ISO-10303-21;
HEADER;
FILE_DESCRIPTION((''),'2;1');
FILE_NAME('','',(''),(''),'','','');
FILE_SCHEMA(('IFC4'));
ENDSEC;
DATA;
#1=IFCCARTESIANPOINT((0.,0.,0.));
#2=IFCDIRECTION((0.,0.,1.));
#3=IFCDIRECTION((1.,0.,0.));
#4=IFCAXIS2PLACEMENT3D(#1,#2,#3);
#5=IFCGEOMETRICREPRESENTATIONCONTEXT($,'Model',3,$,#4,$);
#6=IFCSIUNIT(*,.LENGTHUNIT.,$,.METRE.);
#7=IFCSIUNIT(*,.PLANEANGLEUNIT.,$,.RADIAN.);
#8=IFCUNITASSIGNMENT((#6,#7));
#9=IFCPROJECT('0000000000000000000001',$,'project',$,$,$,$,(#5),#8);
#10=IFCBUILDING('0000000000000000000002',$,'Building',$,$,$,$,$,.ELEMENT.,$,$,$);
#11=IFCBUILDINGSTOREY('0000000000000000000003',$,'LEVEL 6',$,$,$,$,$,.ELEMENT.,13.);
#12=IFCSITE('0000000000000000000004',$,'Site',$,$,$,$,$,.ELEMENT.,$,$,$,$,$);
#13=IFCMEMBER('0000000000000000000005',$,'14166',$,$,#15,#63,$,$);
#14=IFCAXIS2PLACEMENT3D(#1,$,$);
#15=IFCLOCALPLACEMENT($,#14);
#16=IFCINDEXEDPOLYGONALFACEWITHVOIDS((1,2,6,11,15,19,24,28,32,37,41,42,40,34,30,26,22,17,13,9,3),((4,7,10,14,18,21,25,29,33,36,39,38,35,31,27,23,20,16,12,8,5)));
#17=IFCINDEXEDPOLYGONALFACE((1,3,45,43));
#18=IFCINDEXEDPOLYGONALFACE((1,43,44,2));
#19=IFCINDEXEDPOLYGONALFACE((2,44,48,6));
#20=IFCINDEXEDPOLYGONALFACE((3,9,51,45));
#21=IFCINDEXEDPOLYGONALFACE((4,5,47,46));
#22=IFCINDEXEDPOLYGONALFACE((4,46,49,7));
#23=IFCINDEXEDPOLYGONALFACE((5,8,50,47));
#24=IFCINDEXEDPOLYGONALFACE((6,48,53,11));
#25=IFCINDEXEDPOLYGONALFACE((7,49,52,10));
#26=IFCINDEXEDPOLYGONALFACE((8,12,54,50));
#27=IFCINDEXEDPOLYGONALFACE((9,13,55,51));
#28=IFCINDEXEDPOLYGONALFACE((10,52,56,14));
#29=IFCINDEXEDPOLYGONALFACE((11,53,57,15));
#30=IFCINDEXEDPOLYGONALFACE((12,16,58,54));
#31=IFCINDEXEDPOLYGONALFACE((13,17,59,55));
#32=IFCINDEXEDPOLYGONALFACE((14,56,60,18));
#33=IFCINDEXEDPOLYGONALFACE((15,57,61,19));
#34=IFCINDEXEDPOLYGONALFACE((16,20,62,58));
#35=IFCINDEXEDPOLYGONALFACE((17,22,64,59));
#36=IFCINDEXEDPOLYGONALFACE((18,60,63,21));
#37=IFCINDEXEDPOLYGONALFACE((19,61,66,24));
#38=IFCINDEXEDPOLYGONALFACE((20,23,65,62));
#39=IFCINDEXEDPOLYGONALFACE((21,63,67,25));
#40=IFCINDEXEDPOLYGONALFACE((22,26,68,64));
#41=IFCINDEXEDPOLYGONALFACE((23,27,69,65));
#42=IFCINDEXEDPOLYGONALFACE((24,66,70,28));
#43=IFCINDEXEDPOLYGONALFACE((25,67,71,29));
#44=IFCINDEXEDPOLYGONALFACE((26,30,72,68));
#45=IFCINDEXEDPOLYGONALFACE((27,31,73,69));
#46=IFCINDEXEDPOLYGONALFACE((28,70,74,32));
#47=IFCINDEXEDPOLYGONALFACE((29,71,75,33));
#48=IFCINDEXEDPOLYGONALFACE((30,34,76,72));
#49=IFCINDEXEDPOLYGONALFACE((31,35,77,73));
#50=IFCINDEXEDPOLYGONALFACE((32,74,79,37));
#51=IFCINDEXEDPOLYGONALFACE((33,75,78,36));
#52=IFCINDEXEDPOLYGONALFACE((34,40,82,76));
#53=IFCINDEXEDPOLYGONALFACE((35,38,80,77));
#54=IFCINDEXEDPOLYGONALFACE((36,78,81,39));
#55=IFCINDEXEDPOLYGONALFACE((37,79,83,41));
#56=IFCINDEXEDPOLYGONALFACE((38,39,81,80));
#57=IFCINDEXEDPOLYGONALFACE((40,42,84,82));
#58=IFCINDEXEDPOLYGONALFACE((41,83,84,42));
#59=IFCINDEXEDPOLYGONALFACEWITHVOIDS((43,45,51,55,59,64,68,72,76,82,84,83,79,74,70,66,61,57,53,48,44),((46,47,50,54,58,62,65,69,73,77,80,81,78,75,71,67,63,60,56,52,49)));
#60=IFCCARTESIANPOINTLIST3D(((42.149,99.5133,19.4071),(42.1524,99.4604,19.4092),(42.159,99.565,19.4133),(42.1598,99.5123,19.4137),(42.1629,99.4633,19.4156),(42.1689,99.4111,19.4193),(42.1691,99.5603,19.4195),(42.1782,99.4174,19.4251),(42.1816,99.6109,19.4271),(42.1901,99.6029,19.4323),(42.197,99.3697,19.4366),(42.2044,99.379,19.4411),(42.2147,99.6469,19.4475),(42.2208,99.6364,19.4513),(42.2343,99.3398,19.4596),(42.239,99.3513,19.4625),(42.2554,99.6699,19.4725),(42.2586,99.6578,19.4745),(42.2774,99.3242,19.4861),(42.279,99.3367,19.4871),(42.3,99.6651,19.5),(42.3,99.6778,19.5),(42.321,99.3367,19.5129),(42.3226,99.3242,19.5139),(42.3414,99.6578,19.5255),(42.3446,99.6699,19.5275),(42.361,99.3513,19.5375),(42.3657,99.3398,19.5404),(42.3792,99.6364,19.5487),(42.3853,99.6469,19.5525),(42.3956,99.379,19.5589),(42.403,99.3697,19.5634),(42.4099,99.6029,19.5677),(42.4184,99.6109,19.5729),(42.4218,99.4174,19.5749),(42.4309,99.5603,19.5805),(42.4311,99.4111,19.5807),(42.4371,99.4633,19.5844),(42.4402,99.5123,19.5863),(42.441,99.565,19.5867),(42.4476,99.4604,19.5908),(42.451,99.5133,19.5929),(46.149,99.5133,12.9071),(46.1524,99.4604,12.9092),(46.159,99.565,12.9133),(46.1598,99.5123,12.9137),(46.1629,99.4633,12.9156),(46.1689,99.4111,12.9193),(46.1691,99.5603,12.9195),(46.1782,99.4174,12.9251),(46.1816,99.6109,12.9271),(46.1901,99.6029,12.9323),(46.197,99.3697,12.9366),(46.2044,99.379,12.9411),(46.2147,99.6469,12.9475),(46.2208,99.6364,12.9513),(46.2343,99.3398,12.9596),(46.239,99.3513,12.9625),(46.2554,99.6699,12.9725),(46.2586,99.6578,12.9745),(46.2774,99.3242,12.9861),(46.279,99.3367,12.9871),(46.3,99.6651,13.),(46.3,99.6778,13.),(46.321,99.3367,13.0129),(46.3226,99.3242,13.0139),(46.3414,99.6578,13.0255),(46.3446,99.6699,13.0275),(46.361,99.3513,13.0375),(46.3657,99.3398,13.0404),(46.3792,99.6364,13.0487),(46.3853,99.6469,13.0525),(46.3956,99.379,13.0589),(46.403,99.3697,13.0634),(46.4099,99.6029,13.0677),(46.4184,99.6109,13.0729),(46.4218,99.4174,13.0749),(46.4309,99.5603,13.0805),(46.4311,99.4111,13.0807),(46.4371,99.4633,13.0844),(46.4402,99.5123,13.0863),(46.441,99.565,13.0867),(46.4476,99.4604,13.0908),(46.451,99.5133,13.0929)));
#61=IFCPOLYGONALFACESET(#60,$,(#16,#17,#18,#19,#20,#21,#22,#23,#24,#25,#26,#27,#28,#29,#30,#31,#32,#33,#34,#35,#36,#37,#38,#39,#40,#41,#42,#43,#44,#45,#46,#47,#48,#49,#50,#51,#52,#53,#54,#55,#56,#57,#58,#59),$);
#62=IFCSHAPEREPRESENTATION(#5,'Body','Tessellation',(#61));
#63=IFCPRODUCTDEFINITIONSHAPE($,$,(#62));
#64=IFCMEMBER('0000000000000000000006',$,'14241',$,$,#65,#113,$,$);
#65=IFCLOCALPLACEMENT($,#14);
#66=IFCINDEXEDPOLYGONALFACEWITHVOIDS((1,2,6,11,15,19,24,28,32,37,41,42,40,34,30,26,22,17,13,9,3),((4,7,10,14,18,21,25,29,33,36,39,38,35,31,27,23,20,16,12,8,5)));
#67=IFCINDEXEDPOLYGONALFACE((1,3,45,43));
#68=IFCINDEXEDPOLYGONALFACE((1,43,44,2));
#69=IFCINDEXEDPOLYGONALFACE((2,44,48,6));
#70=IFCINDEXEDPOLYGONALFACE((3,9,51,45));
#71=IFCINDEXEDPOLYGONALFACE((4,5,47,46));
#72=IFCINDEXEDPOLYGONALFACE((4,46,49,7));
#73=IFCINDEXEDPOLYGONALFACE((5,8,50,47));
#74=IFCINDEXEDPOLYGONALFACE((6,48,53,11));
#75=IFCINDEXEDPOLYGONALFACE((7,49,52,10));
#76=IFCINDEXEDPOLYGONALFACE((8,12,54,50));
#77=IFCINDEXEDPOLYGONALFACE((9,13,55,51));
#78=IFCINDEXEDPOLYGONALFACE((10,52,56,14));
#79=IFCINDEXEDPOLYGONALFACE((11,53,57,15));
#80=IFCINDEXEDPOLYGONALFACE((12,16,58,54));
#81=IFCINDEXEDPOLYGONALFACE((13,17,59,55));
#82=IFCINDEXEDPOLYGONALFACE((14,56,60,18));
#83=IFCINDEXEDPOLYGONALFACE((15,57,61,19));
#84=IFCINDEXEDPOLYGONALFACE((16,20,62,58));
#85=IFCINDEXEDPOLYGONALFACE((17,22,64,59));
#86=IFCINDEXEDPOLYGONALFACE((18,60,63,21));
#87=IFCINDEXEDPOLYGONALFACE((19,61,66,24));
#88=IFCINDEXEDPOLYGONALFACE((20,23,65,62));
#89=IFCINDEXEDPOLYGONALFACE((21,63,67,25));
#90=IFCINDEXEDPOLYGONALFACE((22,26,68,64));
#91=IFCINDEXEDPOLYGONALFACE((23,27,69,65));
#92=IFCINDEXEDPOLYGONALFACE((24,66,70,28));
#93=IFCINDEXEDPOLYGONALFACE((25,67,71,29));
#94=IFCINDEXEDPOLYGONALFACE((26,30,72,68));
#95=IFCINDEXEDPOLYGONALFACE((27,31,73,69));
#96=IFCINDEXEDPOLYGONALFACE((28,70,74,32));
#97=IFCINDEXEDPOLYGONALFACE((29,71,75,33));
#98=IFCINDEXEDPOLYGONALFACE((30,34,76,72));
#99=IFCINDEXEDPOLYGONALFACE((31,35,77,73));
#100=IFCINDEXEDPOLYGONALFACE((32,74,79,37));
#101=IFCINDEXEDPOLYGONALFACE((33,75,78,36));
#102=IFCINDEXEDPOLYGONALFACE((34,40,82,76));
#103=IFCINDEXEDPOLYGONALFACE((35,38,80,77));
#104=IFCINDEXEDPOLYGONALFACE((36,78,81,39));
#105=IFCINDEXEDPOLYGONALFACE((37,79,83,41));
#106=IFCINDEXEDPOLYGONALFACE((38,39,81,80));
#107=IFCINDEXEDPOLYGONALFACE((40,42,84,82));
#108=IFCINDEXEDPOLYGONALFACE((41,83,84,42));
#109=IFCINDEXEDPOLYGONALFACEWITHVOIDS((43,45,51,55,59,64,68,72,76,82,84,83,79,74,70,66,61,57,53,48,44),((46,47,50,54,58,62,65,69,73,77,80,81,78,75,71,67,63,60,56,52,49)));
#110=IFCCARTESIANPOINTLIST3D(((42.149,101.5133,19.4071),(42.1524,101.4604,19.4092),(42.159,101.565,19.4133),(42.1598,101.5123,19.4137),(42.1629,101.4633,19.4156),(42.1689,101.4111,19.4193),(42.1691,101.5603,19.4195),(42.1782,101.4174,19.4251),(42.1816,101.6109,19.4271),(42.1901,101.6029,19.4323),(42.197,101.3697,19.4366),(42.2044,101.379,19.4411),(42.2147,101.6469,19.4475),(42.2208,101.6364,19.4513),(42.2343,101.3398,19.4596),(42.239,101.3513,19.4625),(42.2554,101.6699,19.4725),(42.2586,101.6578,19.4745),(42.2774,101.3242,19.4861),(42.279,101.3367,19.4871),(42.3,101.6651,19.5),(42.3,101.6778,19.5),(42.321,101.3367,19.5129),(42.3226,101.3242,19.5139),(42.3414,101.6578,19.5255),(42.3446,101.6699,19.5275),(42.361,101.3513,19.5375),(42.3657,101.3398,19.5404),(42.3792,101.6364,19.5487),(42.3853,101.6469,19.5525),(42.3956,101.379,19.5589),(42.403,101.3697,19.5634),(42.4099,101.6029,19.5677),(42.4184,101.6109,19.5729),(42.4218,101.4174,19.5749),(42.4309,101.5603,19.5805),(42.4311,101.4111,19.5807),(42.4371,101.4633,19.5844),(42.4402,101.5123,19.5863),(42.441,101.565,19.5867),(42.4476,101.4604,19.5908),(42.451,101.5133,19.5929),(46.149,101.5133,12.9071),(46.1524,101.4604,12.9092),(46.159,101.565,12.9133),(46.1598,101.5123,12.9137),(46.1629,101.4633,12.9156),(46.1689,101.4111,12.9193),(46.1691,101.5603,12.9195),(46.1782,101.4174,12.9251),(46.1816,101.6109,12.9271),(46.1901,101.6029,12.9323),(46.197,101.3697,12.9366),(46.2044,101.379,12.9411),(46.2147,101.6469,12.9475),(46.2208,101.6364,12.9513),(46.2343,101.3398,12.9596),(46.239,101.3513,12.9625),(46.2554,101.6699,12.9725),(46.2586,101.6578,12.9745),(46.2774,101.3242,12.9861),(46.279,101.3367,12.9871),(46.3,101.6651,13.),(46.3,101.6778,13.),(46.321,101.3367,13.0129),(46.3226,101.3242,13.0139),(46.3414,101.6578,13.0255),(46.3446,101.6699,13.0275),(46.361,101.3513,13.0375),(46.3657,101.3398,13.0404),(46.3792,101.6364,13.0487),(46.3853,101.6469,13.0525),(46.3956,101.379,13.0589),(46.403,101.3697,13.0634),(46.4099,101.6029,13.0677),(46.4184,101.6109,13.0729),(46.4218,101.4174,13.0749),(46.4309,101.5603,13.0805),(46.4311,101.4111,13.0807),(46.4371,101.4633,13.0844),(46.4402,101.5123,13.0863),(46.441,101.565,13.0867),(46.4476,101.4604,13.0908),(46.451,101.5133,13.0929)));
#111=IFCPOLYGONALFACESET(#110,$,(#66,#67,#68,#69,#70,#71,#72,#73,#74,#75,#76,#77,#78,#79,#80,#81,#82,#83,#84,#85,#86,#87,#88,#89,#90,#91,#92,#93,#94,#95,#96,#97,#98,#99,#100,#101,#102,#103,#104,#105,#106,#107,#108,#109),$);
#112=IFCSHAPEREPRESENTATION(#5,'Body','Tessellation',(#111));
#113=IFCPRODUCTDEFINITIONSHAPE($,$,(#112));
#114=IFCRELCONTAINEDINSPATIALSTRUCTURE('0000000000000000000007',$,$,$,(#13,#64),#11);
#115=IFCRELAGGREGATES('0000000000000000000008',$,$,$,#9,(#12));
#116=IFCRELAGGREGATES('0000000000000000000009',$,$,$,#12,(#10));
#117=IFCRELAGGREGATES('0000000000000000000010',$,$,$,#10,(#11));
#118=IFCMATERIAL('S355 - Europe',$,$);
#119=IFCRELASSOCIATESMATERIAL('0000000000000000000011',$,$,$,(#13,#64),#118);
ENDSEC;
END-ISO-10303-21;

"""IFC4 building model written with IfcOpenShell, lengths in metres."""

from ifc_helpers import new_model, si_unit, frame, origin_with_axes, origin_2d_with_axis, place, context, project, spatial, hollow_circle, extrude, material, material_profile, profile_set, profile_usage, element, save


model = new_model("IFC4")

# Units and contexts
model_context = context("Model", 3, world=origin_with_axes())
ifc_project = project(units=[si_unit("LENGTHUNIT", "METRE"), si_unit("PLANEANGLEUNIT", "RADIAN")], contexts=[model_context])

# Site, building, storey
site = spatial("IfcSite", under=ifc_project, Name="Site", CompositionType="ELEMENT")
building = spatial("IfcBuilding", under=site, Name="Building", CompositionType="ELEMENT")
storey = spatial("IfcBuildingStorey", under=building, Name="LEVEL 6", CompositionType="ELEMENT", Elevation=13.0)

# Shared definitions
ifc_material = material(Name="S355 - Europe")

# Members
ifc_material_profile_1 = material_profile(ifc_material, hollow_circle(Radius=0.1778, WallThickness=0.0127, at=origin_2d_with_axis()))
ifc_profile_set_1 = profile_set([ifc_material_profile_1])
ifc_profile_usage_1 = profile_usage(ifc_profile_set_1, cardinal=10)
member_1_placement = place(None, frame((42.3, 99.5, 19.5), z_axis=(0.524097, 0.0, -0.851658), x_axis=(0.0, 1.0, 0.0)))
element("IfcMember", 1, at=member_1_placement, inside=storey, material=ifc_profile_usage_1, Name="14166", context=model_context, shape_type="SweptSolid", body=[
    extrude(hollow_circle(Radius=0.1778, WallThickness=0.0127, at=origin_2d_with_axis()), origin_with_axes(), (0.0, 0.0, 1.0), 7.6322),
])
ifc_material_profile_2 = material_profile(ifc_material, hollow_circle(Radius=0.1778, WallThickness=0.0127, at=origin_2d_with_axis()))
ifc_profile_set_2 = profile_set([ifc_material_profile_2])
ifc_profile_usage_2 = profile_usage(ifc_profile_set_2, cardinal=10)
member_2_placement = place(None, frame((42.3, 101.5, 19.5), z_axis=(0.524097, 0.0, -0.851658), x_axis=(0.0, 1.0, 0.0)))
element("IfcMember", 2, at=member_2_placement, inside=storey, material=ifc_profile_usage_2, Name="14241", context=model_context, shape_type="SweptSolid", body=[
    extrude(hollow_circle(Radius=0.1778, WallThickness=0.0127, at=origin_2d_with_axis()), origin_with_axes(), (0.0, 0.0, 1.0), 7.6322),
])

save(model, "model.ifc")
